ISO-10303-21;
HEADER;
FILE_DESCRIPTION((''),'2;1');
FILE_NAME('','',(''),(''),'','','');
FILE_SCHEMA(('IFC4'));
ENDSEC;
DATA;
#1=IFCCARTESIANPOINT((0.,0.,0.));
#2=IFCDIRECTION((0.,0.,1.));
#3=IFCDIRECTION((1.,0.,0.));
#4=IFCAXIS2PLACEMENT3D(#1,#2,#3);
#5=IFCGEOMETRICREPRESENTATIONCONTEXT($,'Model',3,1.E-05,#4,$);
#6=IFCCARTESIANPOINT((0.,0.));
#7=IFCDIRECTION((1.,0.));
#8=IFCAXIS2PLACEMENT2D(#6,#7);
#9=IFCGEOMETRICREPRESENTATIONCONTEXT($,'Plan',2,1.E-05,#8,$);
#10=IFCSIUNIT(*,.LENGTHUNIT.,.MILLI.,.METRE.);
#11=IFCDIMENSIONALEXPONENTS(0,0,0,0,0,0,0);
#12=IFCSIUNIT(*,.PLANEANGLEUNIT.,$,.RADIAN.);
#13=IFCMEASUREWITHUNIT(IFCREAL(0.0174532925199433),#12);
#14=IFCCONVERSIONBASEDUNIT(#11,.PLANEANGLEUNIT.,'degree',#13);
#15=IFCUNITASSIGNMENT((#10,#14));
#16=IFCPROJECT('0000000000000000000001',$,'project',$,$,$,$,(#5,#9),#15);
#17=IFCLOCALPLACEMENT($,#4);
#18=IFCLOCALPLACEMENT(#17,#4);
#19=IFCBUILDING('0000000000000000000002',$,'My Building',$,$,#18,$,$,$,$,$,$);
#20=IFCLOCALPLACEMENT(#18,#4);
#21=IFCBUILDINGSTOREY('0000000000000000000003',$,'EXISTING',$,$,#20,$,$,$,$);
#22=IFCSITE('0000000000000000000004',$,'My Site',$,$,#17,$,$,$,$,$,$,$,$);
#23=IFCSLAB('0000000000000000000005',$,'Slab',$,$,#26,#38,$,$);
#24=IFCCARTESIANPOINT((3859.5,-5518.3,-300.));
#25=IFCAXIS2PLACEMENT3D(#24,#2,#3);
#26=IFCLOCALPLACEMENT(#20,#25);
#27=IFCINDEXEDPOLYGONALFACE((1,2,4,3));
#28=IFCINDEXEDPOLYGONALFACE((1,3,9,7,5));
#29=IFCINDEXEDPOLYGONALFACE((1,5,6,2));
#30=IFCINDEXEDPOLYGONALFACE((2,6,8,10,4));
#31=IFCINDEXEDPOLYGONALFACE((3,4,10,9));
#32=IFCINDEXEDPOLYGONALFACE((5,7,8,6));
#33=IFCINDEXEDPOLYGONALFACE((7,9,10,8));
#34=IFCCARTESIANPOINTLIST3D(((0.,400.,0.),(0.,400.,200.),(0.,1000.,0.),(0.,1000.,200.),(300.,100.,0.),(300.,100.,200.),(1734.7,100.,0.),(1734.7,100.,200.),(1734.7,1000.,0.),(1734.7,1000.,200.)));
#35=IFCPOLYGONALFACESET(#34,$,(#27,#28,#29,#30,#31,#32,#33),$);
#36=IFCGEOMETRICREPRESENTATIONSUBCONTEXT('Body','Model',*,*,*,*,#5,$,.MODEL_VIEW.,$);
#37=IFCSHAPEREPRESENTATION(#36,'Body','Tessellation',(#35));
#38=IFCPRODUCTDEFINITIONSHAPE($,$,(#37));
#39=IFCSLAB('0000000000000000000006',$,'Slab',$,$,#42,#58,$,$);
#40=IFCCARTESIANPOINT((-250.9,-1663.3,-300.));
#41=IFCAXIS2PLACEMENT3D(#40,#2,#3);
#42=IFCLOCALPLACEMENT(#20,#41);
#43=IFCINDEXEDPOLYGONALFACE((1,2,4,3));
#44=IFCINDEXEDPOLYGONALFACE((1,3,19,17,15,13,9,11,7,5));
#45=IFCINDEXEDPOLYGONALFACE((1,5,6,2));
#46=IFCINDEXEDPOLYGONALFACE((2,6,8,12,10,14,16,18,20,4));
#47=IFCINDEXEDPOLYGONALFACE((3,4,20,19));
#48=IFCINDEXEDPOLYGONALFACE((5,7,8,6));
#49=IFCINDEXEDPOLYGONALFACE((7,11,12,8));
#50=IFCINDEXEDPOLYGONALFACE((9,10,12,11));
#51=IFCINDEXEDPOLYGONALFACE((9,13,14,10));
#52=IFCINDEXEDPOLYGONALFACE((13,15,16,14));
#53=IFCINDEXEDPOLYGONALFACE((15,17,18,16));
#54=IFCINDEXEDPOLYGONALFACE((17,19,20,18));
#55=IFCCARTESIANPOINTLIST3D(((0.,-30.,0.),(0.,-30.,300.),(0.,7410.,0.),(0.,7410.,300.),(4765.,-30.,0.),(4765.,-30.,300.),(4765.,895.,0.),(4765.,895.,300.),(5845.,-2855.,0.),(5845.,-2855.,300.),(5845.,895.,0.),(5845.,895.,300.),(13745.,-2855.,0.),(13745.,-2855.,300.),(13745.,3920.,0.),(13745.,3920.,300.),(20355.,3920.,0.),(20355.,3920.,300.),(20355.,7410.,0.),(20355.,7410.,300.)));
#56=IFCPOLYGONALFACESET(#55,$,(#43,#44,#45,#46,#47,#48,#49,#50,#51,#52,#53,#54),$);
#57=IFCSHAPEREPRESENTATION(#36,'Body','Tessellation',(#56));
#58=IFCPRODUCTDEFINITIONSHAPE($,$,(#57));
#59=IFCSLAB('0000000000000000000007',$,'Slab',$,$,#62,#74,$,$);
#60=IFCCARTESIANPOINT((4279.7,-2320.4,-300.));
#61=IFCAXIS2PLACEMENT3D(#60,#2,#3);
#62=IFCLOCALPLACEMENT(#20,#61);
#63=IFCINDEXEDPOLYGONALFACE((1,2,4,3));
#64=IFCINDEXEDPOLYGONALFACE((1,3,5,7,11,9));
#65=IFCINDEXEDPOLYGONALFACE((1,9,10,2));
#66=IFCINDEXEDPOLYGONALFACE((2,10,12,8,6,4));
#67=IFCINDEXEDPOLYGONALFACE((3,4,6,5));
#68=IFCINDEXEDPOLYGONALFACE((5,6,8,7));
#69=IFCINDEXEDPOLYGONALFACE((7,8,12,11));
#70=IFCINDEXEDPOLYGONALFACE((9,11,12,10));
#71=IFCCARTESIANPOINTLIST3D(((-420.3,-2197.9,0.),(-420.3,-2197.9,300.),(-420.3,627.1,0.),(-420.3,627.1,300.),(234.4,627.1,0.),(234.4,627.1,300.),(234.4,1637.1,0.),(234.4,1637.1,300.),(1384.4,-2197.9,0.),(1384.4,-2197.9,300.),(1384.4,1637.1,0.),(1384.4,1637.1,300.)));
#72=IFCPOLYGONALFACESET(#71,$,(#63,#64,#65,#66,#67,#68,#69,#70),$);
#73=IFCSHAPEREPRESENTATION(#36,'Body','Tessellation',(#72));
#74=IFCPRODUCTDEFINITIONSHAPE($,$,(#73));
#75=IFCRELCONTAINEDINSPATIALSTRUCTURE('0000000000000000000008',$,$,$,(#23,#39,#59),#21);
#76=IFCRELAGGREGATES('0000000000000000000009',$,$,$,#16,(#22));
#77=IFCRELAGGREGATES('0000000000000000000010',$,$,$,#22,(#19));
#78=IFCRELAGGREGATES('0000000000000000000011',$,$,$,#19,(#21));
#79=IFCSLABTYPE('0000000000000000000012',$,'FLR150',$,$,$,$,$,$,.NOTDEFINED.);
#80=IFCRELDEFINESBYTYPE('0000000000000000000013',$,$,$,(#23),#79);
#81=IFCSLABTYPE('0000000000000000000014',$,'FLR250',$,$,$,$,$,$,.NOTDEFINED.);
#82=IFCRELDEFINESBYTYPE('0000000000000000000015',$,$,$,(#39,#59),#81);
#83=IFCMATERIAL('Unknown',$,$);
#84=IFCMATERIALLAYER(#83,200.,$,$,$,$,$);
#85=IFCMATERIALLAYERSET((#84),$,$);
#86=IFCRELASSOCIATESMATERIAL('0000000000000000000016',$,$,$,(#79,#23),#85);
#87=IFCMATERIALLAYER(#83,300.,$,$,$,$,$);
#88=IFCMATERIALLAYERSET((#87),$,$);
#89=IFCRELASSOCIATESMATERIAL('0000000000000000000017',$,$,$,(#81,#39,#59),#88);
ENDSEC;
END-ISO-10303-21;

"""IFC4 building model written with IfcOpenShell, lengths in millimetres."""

from ifc_helpers import new_model, entity, si_unit, converted_unit, frame, origin_with_axes, origin_2d_with_axis, place, context, subcontext, project, spatial, line, indexed_curve, outline, extrude, material, layer, layer_set, layer_usage, type_object, element, save


model = new_model("IFC4")

# Units and contexts
model_context = context("Model", 3, precision=1e-05, world=origin_with_axes())
plan_context = context("Plan", 2, precision=1e-05, world=origin_2d_with_axis())
body_context = subcontext(model_context, "Body", "Model", "MODEL_VIEW")
ifc_project = project(units=[si_unit("LENGTHUNIT", "METRE", prefix="MILLI"), converted_unit("PLANEANGLEUNIT", "degree", entity("IfcReal", 0.0174532925199433), si_unit("PLANEANGLEUNIT", "RADIAN"), dimensions=[0, 0, 0, 0, 0, 0, 0])], contexts=[model_context, plan_context])

# Site, building, storey
site_placement = place(None, origin_with_axes())
site = spatial("IfcSite", under=ifc_project, at=site_placement, Name="My Site")
building_placement = place(site_placement, origin_with_axes())
building = spatial("IfcBuilding", under=site, at=building_placement, Name="My Building")
storey_placement = place(building_placement, origin_with_axes())
storey = spatial("IfcBuildingStorey", under=building, at=storey_placement, Name="EXISTING")

# Slabs
ifc_material = material(Name="Unknown")
ifc_layer_1 = layer(ifc_material, 200.0)
ifc_layer_set_1 = layer_set([ifc_layer_1])
ifc_layer_usage_1 = layer_usage(ifc_layer_set_1, "AXIS3", "POSITIVE", 0.0)
slab_type_1 = type_object("IfcSlabType", Name="FLR150", PredefinedType="NOTDEFINED", material=ifc_layer_set_1)
slab_1_placement = place(storey_placement, frame((3859.5, -5518.3, -300.0), z_axis=(0.0, 0.0, 1.0), x_axis=(1.0, 0.0, 0.0)))
element("IfcSlab", 1, at=slab_1_placement, inside=storey, type_object=slab_type_1, material=ifc_layer_usage_1, Name="Slab", context=body_context, shape_type="SweptSolid", body=[
    extrude(outline(indexed_curve([(0.0, 400.0), (1734.7, 100.0), (1734.7, 1000.0), (0.0, 1000.0), (300.0, 100.0)], segments=[line(4, 1), line(1, 5), line(5, 2), line(2, 3), line(3, 4)], self_intersect=False)), None, (0.0, 0.0, 1.0), 200.0),
])
ifc_layer_2 = layer(ifc_material, 300.0)
ifc_layer_set_2 = layer_set([ifc_layer_2])
ifc_layer_usage_2 = layer_usage(ifc_layer_set_2, "AXIS3", "POSITIVE", 0.0)
slab_type_2 = type_object("IfcSlabType", Name="FLR250", PredefinedType="NOTDEFINED", material=ifc_layer_set_2)
slab_2_placement = place(storey_placement, frame((-250.9, -1663.3, -300.0), z_axis=(0.0, 0.0, 1.0), x_axis=(1.0, 0.0, 0.0)))
element("IfcSlab", 2, at=slab_2_placement, inside=storey, type_object=slab_type_2, material=ifc_layer_usage_2, Name="Slab", context=body_context, shape_type="SweptSolid", body=[
    extrude(outline(indexed_curve([(20355.0, 3920.0), (20355.0, 7410.0), (0.0, 7410.0), (0.0, -30.0), (4765.0, -30.0), (4765.0, 895.0), (5845.0, 895.0), (5845.0, -2855.0), (13745.0, -2855.0), (13745.0, 3920.0)], segments=[line(3, 2), line(2, 1), line(1, 10), line(10, 9), line(9, 8), line(8, 7), line(7, 6), line(6, 5), line(5, 4), line(4, 3)], self_intersect=False)), None, (0.0, 0.0, 1.0), 300.0),
])
ifc_layer_usage_3 = layer_usage(ifc_layer_set_2, "AXIS3", "POSITIVE", 0.0)
slab_3_placement = place(storey_placement, frame((4279.7, -2320.4, -300.0), z_axis=(0.0, 0.0, 1.0), x_axis=(1.0, 0.0, 0.0)))
element("IfcSlab", 3, at=slab_3_placement, inside=storey, type_object=slab_type_2, material=ifc_layer_usage_3, Name="Slab", context=body_context, shape_type="SweptSolid", body=[
    extrude(outline(indexed_curve([(-420.3, -2197.9), (-420.3, 627.1), (234.4, 627.1), (234.4, 1637.1), (1384.4, 1637.1), (1384.4, -2197.9)], segments=[line(4, 3), line(3, 2), line(2, 1), line(1, 6), line(6, 5), line(5, 4)], self_intersect=False)), None, (0.0, 0.0, 1.0), 300.0),
])

save(model, "model.ifc")
